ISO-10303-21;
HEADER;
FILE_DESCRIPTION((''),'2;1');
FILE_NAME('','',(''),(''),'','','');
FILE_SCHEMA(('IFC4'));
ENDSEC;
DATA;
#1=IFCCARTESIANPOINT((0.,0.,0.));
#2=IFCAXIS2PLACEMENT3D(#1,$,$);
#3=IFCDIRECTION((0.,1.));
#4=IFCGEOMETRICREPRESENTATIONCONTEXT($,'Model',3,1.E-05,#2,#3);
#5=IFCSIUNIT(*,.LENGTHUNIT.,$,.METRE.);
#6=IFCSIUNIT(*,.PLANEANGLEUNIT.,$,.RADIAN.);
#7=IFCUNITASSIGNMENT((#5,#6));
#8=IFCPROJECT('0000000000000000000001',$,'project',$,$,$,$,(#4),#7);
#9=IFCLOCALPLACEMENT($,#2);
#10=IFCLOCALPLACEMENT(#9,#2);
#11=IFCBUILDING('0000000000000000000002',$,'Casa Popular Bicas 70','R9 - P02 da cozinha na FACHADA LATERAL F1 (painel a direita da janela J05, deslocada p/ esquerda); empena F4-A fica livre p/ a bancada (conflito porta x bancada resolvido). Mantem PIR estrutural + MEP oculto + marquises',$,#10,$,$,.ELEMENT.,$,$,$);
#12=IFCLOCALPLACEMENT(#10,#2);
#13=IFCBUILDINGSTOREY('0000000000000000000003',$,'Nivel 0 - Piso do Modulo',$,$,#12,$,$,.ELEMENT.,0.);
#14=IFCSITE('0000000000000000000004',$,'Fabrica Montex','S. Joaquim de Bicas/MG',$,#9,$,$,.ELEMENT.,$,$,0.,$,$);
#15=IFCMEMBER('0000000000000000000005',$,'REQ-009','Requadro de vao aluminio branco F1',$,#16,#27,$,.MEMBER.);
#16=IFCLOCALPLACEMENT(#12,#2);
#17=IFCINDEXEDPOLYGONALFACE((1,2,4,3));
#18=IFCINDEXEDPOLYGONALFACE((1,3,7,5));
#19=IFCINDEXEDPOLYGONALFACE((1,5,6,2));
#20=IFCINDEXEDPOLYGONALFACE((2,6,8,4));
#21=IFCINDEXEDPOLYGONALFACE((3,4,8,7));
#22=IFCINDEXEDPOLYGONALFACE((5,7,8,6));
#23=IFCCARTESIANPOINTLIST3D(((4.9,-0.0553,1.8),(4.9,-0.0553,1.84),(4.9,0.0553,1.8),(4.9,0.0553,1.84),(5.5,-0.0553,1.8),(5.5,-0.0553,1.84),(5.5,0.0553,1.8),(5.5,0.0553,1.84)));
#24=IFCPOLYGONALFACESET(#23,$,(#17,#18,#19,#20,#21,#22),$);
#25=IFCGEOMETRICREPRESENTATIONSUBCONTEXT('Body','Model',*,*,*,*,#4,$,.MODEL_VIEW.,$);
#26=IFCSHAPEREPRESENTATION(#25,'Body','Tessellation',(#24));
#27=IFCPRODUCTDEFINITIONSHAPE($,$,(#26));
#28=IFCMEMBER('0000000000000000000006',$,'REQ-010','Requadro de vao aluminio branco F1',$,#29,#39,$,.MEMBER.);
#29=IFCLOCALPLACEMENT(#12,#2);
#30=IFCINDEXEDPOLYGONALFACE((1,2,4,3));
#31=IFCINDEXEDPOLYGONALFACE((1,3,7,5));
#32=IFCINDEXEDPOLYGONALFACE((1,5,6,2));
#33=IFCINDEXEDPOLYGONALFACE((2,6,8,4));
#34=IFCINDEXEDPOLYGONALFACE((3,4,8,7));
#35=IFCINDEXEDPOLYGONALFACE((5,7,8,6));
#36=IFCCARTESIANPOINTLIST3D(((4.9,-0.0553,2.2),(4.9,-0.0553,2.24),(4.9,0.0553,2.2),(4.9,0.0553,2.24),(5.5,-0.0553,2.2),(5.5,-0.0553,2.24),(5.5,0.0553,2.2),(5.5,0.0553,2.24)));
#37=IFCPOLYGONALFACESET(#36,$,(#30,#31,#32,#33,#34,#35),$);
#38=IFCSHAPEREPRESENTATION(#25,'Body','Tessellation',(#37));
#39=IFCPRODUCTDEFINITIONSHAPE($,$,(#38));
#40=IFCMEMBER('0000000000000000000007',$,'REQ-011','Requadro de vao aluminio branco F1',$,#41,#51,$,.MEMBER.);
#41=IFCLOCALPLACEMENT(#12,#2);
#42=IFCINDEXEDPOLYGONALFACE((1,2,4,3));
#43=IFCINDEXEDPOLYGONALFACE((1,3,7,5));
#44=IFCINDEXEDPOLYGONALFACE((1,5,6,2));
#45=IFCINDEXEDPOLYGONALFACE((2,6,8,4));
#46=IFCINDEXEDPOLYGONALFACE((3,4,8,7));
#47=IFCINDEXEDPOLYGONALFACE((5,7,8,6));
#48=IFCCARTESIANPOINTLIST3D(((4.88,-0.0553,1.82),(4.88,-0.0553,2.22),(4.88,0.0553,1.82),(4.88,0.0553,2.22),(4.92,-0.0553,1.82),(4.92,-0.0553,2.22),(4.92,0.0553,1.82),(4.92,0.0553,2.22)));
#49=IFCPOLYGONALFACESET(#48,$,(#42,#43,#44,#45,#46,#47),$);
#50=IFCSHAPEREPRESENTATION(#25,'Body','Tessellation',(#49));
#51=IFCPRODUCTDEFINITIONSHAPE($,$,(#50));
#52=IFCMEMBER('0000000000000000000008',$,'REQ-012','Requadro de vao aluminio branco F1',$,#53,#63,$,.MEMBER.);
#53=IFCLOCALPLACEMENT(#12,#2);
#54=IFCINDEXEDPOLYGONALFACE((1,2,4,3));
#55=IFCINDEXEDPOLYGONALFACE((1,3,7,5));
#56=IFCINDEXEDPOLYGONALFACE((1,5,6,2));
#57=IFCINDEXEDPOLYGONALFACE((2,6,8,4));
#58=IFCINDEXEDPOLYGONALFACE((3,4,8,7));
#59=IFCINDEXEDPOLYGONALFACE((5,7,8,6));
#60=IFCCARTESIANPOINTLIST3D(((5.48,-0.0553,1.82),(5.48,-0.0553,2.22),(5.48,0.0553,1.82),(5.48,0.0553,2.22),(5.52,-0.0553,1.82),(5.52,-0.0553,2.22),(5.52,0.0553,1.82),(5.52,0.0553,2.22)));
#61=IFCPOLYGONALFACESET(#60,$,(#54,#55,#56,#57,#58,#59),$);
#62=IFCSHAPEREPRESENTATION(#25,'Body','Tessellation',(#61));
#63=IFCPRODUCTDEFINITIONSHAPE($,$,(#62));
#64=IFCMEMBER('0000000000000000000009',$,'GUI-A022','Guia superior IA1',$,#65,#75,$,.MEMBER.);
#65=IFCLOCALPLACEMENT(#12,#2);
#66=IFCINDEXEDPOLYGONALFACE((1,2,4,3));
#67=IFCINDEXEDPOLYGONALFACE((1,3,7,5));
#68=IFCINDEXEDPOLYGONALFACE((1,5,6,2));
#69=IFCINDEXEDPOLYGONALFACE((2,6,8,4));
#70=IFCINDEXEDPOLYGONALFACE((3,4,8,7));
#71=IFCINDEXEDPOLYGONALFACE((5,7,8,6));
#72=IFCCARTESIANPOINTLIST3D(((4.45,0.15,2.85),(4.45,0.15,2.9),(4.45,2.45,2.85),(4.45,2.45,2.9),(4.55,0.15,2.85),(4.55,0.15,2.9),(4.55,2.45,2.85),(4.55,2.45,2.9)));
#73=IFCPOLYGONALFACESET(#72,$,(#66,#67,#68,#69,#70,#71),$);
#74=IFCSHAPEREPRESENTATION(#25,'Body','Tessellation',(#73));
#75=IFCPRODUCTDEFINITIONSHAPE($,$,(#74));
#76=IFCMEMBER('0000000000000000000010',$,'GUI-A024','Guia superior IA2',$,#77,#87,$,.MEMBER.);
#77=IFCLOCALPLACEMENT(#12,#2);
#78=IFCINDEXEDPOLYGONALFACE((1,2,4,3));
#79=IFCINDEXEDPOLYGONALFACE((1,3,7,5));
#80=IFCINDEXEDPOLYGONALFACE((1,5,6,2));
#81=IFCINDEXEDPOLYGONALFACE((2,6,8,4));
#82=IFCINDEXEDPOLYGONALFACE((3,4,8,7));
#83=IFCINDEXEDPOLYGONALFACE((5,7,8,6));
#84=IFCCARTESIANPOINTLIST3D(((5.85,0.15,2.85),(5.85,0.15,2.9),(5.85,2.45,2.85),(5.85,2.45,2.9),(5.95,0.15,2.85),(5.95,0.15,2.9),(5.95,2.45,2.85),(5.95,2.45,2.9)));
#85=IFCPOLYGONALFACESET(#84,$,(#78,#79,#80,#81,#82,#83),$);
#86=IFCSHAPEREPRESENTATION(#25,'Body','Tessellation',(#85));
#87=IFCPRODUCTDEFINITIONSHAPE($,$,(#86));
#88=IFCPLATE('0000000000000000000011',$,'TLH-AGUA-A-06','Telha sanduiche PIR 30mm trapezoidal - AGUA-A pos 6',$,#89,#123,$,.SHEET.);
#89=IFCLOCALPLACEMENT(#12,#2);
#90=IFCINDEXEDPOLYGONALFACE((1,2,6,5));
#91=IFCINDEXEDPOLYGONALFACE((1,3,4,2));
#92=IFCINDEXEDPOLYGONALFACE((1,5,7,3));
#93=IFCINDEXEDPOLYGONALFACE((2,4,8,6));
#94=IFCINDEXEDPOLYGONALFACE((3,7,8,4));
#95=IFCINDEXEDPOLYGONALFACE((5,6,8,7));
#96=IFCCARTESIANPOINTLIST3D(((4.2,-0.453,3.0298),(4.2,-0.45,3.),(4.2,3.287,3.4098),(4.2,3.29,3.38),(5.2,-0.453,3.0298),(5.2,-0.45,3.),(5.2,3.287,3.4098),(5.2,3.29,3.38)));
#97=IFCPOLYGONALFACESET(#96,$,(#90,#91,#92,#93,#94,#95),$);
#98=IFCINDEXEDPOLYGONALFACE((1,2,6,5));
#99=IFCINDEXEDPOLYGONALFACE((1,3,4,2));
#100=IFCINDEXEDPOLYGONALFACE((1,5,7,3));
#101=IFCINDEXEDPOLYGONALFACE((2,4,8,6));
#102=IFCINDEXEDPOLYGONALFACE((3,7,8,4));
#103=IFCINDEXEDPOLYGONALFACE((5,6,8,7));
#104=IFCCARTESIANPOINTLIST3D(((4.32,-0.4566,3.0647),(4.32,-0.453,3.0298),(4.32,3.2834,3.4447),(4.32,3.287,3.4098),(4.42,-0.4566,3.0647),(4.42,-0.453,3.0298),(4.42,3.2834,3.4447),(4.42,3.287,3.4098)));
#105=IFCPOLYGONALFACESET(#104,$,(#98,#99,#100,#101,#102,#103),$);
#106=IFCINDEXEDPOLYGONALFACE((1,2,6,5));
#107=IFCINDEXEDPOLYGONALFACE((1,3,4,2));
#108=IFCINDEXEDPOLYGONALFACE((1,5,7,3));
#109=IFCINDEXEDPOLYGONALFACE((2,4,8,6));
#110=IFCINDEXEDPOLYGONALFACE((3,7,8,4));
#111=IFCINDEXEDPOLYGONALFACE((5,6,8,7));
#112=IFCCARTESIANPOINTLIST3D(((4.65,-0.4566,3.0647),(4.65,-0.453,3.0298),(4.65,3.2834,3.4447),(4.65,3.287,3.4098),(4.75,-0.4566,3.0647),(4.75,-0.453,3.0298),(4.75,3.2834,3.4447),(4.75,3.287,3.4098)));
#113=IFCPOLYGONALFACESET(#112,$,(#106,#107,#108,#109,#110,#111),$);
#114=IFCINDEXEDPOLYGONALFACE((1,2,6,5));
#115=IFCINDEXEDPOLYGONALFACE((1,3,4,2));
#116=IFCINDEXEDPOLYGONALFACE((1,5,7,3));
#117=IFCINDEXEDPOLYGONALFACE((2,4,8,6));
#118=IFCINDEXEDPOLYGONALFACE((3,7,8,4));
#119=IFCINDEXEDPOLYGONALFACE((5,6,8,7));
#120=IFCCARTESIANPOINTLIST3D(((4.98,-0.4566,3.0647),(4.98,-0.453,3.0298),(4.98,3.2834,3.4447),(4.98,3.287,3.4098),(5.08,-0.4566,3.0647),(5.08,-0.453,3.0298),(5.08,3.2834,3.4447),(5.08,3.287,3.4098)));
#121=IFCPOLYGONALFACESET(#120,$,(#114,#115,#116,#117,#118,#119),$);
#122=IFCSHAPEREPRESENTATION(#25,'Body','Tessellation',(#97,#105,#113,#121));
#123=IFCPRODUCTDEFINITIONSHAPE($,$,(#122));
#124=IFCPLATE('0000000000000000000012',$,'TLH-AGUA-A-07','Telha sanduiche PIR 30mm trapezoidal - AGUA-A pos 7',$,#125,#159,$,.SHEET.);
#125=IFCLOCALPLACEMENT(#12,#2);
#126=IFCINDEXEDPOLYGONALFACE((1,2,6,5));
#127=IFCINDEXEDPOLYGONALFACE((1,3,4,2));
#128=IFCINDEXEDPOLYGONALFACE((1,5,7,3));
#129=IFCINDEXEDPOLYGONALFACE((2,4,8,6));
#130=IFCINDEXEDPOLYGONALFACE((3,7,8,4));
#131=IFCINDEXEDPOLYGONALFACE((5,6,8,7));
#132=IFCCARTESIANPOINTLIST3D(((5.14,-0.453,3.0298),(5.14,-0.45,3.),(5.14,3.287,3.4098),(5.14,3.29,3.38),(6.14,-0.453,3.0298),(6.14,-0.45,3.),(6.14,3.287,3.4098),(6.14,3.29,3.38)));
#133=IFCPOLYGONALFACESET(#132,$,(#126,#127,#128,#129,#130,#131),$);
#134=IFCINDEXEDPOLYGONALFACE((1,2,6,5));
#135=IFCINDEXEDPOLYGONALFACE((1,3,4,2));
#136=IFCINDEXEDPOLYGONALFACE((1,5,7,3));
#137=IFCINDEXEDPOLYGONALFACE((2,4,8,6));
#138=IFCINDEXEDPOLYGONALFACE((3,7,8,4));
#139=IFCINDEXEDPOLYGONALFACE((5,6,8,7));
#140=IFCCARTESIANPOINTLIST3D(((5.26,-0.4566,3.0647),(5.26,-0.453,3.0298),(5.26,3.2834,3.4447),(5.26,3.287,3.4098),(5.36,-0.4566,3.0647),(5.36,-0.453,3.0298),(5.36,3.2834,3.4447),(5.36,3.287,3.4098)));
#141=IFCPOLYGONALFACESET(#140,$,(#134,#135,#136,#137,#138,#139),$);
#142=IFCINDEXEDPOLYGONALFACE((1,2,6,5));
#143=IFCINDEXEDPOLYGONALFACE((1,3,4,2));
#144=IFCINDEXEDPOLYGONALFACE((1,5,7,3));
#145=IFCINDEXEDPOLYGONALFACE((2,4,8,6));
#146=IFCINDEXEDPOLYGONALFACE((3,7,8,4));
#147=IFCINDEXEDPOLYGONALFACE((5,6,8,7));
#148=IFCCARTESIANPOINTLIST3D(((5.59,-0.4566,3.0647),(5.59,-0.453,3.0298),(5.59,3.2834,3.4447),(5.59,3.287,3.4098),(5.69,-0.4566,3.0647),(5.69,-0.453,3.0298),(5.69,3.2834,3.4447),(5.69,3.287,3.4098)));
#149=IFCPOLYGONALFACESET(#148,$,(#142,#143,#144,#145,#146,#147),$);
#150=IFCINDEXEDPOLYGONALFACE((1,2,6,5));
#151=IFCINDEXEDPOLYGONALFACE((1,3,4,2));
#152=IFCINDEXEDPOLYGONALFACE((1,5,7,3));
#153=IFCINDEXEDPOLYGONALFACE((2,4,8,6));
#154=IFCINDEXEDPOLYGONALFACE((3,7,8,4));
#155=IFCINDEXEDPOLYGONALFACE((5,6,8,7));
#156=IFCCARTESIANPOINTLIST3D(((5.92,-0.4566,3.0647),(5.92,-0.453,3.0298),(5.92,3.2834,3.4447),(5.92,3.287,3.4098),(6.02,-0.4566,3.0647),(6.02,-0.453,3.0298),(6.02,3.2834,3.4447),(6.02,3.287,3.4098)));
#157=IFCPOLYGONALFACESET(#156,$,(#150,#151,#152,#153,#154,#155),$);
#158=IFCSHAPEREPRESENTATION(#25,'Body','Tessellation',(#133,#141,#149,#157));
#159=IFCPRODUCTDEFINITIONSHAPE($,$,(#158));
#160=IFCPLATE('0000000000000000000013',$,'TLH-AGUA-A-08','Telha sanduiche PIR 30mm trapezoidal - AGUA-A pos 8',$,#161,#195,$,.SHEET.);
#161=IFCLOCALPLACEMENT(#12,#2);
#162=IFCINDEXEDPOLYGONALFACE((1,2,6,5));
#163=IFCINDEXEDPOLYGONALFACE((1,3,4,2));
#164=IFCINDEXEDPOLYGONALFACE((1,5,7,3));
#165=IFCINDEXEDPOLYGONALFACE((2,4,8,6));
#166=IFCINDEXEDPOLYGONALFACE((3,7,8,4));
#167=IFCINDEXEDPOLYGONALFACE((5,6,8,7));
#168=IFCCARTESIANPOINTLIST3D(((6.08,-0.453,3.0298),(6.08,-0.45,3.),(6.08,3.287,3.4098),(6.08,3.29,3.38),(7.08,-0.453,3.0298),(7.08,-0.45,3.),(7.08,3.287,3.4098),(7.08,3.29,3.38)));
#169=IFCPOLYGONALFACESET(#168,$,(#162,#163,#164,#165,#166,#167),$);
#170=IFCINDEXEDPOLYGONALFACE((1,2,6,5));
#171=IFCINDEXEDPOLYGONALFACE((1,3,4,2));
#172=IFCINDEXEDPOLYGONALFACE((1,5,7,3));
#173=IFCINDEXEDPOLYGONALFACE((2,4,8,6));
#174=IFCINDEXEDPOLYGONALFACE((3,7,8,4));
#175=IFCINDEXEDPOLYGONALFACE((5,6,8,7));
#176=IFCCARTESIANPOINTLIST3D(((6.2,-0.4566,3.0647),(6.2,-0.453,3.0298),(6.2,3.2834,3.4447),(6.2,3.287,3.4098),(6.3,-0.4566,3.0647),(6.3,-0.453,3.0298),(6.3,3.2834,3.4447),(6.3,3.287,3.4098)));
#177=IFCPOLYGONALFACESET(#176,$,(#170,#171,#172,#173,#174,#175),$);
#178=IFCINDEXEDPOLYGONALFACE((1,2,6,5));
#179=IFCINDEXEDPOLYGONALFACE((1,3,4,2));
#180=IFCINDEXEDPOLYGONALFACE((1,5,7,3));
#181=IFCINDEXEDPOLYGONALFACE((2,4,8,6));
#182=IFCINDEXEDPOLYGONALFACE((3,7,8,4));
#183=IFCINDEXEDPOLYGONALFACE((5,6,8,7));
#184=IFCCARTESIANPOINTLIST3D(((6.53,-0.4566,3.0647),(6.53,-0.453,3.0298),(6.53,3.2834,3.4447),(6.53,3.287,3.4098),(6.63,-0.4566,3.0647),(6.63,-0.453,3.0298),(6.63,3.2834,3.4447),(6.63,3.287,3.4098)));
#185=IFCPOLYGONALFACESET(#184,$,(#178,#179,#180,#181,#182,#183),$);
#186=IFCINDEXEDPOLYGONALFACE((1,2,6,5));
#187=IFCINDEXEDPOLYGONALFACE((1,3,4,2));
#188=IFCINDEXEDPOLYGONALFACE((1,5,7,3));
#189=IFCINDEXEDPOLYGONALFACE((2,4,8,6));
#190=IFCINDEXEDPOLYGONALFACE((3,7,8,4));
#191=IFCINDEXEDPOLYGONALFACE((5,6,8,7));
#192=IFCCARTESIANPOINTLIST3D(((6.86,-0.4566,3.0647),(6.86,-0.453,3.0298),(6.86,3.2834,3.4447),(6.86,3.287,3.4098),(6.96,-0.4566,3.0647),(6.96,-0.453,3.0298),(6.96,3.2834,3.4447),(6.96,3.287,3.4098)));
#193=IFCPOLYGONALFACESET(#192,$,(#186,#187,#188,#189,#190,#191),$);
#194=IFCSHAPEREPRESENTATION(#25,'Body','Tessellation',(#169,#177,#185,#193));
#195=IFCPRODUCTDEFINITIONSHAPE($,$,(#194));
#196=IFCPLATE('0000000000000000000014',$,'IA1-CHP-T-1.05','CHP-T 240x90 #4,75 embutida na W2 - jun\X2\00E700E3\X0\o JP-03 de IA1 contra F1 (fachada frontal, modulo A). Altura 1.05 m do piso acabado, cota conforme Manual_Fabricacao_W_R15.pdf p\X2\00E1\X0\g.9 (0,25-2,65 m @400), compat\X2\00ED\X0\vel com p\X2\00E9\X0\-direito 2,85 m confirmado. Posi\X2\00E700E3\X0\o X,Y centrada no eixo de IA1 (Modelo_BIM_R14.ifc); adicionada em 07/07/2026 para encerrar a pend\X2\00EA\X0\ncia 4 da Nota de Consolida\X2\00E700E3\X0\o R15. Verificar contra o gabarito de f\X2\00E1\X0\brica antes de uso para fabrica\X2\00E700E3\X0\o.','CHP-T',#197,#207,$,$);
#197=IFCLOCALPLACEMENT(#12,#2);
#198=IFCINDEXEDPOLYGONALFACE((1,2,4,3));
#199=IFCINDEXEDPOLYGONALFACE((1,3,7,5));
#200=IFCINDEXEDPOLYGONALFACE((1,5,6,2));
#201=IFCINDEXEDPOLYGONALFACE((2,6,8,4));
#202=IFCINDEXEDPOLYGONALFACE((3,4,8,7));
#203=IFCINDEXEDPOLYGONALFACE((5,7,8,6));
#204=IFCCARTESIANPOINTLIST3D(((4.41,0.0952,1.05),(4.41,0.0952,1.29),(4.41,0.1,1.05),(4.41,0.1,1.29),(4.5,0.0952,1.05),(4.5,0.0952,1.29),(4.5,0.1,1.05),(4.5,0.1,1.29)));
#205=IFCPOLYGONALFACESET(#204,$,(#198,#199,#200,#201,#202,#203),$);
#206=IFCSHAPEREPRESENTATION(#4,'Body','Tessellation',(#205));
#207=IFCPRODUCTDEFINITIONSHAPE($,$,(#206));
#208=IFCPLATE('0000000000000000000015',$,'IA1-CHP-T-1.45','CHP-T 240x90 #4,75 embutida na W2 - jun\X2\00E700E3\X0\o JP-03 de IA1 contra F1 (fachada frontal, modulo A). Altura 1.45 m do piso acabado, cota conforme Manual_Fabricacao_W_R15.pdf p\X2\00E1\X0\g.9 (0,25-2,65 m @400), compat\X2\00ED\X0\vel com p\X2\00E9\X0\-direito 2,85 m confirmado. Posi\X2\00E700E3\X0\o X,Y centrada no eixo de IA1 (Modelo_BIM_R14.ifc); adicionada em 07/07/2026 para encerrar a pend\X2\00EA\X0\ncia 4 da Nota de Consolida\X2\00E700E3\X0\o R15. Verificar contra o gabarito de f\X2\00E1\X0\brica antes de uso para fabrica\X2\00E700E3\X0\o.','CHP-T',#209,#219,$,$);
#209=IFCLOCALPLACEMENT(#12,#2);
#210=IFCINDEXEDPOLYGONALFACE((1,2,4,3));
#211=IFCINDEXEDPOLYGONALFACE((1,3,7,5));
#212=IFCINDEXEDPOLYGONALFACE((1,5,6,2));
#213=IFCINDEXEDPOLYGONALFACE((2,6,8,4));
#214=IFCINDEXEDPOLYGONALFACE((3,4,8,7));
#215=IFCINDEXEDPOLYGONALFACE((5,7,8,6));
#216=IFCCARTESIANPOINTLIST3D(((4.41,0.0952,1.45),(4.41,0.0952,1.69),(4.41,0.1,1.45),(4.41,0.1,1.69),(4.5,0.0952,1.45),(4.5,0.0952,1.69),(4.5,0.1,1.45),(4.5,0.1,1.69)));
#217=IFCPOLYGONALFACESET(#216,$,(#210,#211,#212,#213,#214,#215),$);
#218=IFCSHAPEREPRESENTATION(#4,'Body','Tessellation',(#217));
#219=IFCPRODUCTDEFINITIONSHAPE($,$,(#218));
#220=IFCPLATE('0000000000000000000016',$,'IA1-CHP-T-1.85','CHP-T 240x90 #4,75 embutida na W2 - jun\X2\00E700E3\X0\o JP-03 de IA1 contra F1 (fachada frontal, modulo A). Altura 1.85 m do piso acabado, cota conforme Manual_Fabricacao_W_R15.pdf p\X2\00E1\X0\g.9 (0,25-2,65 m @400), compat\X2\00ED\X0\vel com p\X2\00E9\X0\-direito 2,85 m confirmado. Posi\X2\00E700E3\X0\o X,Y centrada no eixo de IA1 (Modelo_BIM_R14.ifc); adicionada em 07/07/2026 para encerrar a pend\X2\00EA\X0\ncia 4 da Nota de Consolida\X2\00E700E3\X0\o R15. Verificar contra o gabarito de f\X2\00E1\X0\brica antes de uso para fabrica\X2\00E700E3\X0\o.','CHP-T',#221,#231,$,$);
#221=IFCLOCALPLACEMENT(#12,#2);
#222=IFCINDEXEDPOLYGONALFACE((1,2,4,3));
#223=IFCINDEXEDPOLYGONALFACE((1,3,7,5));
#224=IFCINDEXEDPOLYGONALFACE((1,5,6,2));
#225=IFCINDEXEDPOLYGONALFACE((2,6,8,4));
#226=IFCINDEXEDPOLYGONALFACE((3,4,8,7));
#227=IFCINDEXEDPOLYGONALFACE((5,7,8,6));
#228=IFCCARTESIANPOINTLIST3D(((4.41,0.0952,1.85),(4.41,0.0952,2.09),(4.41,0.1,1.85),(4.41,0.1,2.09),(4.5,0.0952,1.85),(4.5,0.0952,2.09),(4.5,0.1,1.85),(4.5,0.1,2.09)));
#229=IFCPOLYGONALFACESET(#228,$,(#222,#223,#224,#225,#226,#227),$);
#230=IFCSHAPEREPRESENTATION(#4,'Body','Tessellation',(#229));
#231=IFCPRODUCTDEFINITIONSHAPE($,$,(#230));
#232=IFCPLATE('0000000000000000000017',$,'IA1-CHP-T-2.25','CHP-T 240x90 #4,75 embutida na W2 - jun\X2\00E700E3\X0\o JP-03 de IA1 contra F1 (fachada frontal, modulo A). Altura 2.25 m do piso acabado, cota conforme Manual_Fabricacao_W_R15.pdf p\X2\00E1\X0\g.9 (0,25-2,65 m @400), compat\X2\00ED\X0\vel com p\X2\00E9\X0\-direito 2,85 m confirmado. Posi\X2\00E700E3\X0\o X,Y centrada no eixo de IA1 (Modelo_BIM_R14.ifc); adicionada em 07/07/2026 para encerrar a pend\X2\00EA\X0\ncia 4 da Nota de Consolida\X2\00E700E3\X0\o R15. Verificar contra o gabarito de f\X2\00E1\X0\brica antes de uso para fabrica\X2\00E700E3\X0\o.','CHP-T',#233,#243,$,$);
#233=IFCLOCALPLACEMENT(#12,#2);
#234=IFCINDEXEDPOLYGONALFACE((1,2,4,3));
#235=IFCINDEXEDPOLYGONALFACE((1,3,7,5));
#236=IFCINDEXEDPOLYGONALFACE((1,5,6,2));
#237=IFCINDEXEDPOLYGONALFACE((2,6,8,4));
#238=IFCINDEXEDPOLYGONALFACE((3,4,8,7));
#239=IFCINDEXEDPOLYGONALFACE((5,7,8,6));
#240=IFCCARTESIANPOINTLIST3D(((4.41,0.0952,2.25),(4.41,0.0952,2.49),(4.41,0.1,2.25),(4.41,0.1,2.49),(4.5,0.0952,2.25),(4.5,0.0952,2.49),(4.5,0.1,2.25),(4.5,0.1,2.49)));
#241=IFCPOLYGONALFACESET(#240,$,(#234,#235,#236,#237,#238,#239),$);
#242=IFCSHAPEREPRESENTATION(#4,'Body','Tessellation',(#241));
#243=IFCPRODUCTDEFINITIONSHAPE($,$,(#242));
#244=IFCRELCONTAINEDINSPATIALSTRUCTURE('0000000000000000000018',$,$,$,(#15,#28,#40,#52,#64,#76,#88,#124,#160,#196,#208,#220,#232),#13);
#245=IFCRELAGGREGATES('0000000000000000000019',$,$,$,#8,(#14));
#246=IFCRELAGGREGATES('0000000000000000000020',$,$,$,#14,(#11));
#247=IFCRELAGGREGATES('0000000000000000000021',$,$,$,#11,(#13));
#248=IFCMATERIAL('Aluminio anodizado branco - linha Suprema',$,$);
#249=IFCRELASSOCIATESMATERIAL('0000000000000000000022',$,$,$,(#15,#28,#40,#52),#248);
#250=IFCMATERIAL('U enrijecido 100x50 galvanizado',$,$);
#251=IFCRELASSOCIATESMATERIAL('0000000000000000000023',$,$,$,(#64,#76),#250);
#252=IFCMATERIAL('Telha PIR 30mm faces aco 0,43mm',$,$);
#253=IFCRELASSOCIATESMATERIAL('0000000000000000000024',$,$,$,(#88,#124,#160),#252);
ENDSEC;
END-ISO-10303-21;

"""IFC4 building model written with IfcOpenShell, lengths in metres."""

from ifc_helpers import new_model, si_unit, direction, frame, frame_2d, origin, origin_with_axes, origin_2d, place, context, subcontext, project, spatial, rectangle, extrude, material, element, save


model = new_model("IFC4")

# Units and contexts
model_context = context("Model", 3, precision=1e-05, world=origin(), true_north=direction((0.0, 1.0)))
body_context = subcontext(model_context, "Body", "Model", "MODEL_VIEW")
ifc_project = project(units=[si_unit("LENGTHUNIT", "METRE"), si_unit("PLANEANGLEUNIT", "RADIAN")], contexts=[model_context])

# Site, building, storey
site_placement = place(None, origin())
site = spatial("IfcSite", under=ifc_project, at=site_placement, Name="Fabrica Montex", Description="S. Joaquim de Bicas/MG", CompositionType="ELEMENT", RefElevation=0.0)
building_placement = place(site_placement, origin())
building = spatial("IfcBuilding", under=site, at=building_placement, Name="Casa Popular Bicas 70", Description="R9 - P02 da cozinha na FACHADA LATERAL F1 (painel a direita da janela J05, deslocada p/ esquerda); empena F4-A fica livre p/ a bancada (conflito porta x bancada resolvido). Mantem PIR estrutural + MEP oculto + marquises", CompositionType="ELEMENT")
storey_placement = place(building_placement, origin())
storey = spatial("IfcBuildingStorey", under=building, at=storey_placement, Name="Nivel 0 - Piso do Modulo", CompositionType="ELEMENT", Elevation=0.0)

# Members
ifc_material_1 = material(Name="Aluminio anodizado branco - linha Suprema")
for number, where, z_axis, x_axis, name in (
    (1, (4.9, 0.0, 1.82), (1.0, 0.0, 0.0), (0.0, 0.0, 1.0), "REQ-009"),
    (2, (4.9, 0.0, 2.22), (1.0, 0.0, 0.0), (0.0, 0.0, 1.0), "REQ-010"),
):
    element("IfcMember", number, at=place(storey_placement, frame(where, z_axis=z_axis, x_axis=x_axis)), inside=storey, material=ifc_material_1, Name=name, Description="Requadro de vao aluminio branco F1", PredefinedType="MEMBER", context=body_context, shape_type="SweptSolid", body=[
        extrude(rectangle(XDim=0.04, YDim=0.1105, at=origin_2d()), origin(), (0.0, 0.0, 1.0), 0.6),
    ])
for number, where, z_axis, x_axis, name in (
    (3, (4.9, 0.0, 1.82), (0.0, 0.0, 1.0), (1.0, 0.0, 0.0), "REQ-011"),
    (4, (5.5, 0.0, 1.82), (0.0, 0.0, 1.0), (1.0, 0.0, 0.0), "REQ-012"),
):
    element("IfcMember", number, at=place(storey_placement, frame(where, z_axis=z_axis, x_axis=x_axis)), inside=storey, material=ifc_material_1, Name=name, Description="Requadro de vao aluminio branco F1", PredefinedType="MEMBER", context=body_context, shape_type="SweptSolid", body=[
        extrude(rectangle(XDim=0.04, YDim=0.1105, at=origin_2d()), origin(), (0.0, 0.0, 1.0), 0.4),
    ])
ifc_material_2 = material(Name="U enrijecido 100x50 galvanizado")
for number, where, z_axis, x_axis, name, description in (
    (5, (4.5, 0.15, 2.875), (0.0, 1.0, 0.0), (0.0, 0.0, 1.0), "GUI-A022", "Guia superior IA1"),
    (6, (5.9, 0.15, 2.875), (0.0, 1.0, 0.0), (0.0, 0.0, 1.0), "GUI-A024", "Guia superior IA2"),
):
    element("IfcMember", number, at=place(storey_placement, frame(where, z_axis=z_axis, x_axis=x_axis)), inside=storey, material=ifc_material_2, Name=name, Description=description, PredefinedType="MEMBER", context=body_context, shape_type="SweptSolid", body=[
        extrude(rectangle(XDim=0.05, YDim=0.1, at=origin_2d()), origin(), (0.0, 0.0, 1.0), 2.3),
    ])

# Plates
ifc_material_3 = material(Name="Telha PIR 30mm faces aco 0,43mm")
for number, where, z_axis, x_axis, name, description in (
    (7, (4.2, -0.45, 3.0), (0.0, -0.101084, 0.994878), (1.0, 0.0, 0.0), "TLH-AGUA-A-06", "Telha sanduiche PIR 30mm trapezoidal - AGUA-A pos 6"),
    (8, (5.14, -0.45, 3.0), (0.0, -0.101084, 0.994878), (1.0, 0.0, 0.0), "TLH-AGUA-A-07", "Telha sanduiche PIR 30mm trapezoidal - AGUA-A pos 7"),
    (9, (6.08, -0.45, 3.0), (0.0, -0.101084, 0.994878), (1.0, 0.0, 0.0), "TLH-AGUA-A-08", "Telha sanduiche PIR 30mm trapezoidal - AGUA-A pos 8"),
):
    element("IfcPlate", number, at=place(storey_placement, frame(where, z_axis=z_axis, x_axis=x_axis)), inside=storey, material=ifc_material_3, Name=name, Description=description, PredefinedType="SHEET", context=body_context, shape_type="SweptSolid", body=[
        extrude(rectangle(XDim=1.0, YDim=3.7593, at=frame_2d((0.5, 1.8796))), origin(), (0.0, 0.0, 1.0), 0.03),
        extrude(rectangle(XDim=0.1, YDim=3.7593, at=frame_2d((0.17, 1.8796))), frame((0.0, 0.0, 0.03)), (0.0, 0.0, 1.0), 0.035),
        extrude(rectangle(XDim=0.1, YDim=3.7593, at=frame_2d((0.5, 1.8796))), frame((0.0, 0.0, 0.03)), (0.0, 0.0, 1.0), 0.035),
        extrude(rectangle(XDim=0.1, YDim=3.7593, at=frame_2d((0.83, 1.8796))), frame((0.0, 0.0, 0.03)), (0.0, 0.0, 1.0), 0.035),
    ])
for number, where, z_axis, x_axis, name, description in (
    (10, (4.455, 0.0976, 1.05), (0.0, 0.0, 1.0), (1.0, 0.0, 0.0), "IA1-CHP-T-1.05", "CHP-T 240x90 #4,75 embutida na W2 - junção JP-03 de IA1 contra F1 (fachada frontal, modulo A). Altura 1.05 m do piso acabado, cota conforme Manual_Fabricacao_W_R15.pdf pág.9 (0,25-2,65 m @400), compatível com pé-direito 2,85 m confirmado. Posição X,Y centrada no eixo de IA1 (Modelo_BIM_R14.ifc); adicionada em 07/07/2026 para encerrar a pendência 4 da Nota de Consolidação R15. Verificar contra o gabarito de fábrica antes de uso para fabricação."),
    (11, (4.455, 0.0976, 1.45), (0.0, 0.0, 1.0), (1.0, 0.0, 0.0), "IA1-CHP-T-1.45", "CHP-T 240x90 #4,75 embutida na W2 - junção JP-03 de IA1 contra F1 (fachada frontal, modulo A). Altura 1.45 m do piso acabado, cota conforme Manual_Fabricacao_W_R15.pdf pág.9 (0,25-2,65 m @400), compatível com pé-direito 2,85 m confirmado. Posição X,Y centrada no eixo de IA1 (Modelo_BIM_R14.ifc); adicionada em 07/07/2026 para encerrar a pendência 4 da Nota de Consolidação R15. Verificar contra o gabarito de fábrica antes de uso para fabricação."),
    (12, (4.455, 0.0976, 1.85), (0.0, 0.0, 1.0), (1.0, 0.0, 0.0), "IA1-CHP-T-1.85", "CHP-T 240x90 #4,75 embutida na W2 - junção JP-03 de IA1 contra F1 (fachada frontal, modulo A). Altura 1.85 m do piso acabado, cota conforme Manual_Fabricacao_W_R15.pdf pág.9 (0,25-2,65 m @400), compatível com pé-direito 2,85 m confirmado. Posição X,Y centrada no eixo de IA1 (Modelo_BIM_R14.ifc); adicionada em 07/07/2026 para encerrar a pendência 4 da Nota de Consolidação R15. Verificar contra o gabarito de fábrica antes de uso para fabricação."),
    (13, (4.455, 0.0976, 2.25), (0.0, 0.0, 1.0), (1.0, 0.0, 0.0), "IA1-CHP-T-2.25", "CHP-T 240x90 #4,75 embutida na W2 - junção JP-03 de IA1 contra F1 (fachada frontal, modulo A). Altura 2.25 m do piso acabado, cota conforme Manual_Fabricacao_W_R15.pdf pág.9 (0,25-2,65 m @400), compatível com pé-direito 2,85 m confirmado. Posição X,Y centrada no eixo de IA1 (Modelo_BIM_R14.ifc); adicionada em 07/07/2026 para encerrar a pendência 4 da Nota de Consolidação R15. Verificar contra o gabarito de fábrica antes de uso para fabricação."),
):
    element("IfcPlate", number, at=place(storey_placement, frame(where, z_axis=z_axis, x_axis=x_axis)), inside=storey, Name=name, Description=description, ObjectType="CHP-T", context=model_context, shape_type="SweptSolid", body=[
        extrude(rectangle(XDim=0.09, YDim=0.0047, at=origin_2d()), origin_with_axes(), (0.0, 0.0, 1.0), 0.24),
    ])

save(model, "model.ifc")
